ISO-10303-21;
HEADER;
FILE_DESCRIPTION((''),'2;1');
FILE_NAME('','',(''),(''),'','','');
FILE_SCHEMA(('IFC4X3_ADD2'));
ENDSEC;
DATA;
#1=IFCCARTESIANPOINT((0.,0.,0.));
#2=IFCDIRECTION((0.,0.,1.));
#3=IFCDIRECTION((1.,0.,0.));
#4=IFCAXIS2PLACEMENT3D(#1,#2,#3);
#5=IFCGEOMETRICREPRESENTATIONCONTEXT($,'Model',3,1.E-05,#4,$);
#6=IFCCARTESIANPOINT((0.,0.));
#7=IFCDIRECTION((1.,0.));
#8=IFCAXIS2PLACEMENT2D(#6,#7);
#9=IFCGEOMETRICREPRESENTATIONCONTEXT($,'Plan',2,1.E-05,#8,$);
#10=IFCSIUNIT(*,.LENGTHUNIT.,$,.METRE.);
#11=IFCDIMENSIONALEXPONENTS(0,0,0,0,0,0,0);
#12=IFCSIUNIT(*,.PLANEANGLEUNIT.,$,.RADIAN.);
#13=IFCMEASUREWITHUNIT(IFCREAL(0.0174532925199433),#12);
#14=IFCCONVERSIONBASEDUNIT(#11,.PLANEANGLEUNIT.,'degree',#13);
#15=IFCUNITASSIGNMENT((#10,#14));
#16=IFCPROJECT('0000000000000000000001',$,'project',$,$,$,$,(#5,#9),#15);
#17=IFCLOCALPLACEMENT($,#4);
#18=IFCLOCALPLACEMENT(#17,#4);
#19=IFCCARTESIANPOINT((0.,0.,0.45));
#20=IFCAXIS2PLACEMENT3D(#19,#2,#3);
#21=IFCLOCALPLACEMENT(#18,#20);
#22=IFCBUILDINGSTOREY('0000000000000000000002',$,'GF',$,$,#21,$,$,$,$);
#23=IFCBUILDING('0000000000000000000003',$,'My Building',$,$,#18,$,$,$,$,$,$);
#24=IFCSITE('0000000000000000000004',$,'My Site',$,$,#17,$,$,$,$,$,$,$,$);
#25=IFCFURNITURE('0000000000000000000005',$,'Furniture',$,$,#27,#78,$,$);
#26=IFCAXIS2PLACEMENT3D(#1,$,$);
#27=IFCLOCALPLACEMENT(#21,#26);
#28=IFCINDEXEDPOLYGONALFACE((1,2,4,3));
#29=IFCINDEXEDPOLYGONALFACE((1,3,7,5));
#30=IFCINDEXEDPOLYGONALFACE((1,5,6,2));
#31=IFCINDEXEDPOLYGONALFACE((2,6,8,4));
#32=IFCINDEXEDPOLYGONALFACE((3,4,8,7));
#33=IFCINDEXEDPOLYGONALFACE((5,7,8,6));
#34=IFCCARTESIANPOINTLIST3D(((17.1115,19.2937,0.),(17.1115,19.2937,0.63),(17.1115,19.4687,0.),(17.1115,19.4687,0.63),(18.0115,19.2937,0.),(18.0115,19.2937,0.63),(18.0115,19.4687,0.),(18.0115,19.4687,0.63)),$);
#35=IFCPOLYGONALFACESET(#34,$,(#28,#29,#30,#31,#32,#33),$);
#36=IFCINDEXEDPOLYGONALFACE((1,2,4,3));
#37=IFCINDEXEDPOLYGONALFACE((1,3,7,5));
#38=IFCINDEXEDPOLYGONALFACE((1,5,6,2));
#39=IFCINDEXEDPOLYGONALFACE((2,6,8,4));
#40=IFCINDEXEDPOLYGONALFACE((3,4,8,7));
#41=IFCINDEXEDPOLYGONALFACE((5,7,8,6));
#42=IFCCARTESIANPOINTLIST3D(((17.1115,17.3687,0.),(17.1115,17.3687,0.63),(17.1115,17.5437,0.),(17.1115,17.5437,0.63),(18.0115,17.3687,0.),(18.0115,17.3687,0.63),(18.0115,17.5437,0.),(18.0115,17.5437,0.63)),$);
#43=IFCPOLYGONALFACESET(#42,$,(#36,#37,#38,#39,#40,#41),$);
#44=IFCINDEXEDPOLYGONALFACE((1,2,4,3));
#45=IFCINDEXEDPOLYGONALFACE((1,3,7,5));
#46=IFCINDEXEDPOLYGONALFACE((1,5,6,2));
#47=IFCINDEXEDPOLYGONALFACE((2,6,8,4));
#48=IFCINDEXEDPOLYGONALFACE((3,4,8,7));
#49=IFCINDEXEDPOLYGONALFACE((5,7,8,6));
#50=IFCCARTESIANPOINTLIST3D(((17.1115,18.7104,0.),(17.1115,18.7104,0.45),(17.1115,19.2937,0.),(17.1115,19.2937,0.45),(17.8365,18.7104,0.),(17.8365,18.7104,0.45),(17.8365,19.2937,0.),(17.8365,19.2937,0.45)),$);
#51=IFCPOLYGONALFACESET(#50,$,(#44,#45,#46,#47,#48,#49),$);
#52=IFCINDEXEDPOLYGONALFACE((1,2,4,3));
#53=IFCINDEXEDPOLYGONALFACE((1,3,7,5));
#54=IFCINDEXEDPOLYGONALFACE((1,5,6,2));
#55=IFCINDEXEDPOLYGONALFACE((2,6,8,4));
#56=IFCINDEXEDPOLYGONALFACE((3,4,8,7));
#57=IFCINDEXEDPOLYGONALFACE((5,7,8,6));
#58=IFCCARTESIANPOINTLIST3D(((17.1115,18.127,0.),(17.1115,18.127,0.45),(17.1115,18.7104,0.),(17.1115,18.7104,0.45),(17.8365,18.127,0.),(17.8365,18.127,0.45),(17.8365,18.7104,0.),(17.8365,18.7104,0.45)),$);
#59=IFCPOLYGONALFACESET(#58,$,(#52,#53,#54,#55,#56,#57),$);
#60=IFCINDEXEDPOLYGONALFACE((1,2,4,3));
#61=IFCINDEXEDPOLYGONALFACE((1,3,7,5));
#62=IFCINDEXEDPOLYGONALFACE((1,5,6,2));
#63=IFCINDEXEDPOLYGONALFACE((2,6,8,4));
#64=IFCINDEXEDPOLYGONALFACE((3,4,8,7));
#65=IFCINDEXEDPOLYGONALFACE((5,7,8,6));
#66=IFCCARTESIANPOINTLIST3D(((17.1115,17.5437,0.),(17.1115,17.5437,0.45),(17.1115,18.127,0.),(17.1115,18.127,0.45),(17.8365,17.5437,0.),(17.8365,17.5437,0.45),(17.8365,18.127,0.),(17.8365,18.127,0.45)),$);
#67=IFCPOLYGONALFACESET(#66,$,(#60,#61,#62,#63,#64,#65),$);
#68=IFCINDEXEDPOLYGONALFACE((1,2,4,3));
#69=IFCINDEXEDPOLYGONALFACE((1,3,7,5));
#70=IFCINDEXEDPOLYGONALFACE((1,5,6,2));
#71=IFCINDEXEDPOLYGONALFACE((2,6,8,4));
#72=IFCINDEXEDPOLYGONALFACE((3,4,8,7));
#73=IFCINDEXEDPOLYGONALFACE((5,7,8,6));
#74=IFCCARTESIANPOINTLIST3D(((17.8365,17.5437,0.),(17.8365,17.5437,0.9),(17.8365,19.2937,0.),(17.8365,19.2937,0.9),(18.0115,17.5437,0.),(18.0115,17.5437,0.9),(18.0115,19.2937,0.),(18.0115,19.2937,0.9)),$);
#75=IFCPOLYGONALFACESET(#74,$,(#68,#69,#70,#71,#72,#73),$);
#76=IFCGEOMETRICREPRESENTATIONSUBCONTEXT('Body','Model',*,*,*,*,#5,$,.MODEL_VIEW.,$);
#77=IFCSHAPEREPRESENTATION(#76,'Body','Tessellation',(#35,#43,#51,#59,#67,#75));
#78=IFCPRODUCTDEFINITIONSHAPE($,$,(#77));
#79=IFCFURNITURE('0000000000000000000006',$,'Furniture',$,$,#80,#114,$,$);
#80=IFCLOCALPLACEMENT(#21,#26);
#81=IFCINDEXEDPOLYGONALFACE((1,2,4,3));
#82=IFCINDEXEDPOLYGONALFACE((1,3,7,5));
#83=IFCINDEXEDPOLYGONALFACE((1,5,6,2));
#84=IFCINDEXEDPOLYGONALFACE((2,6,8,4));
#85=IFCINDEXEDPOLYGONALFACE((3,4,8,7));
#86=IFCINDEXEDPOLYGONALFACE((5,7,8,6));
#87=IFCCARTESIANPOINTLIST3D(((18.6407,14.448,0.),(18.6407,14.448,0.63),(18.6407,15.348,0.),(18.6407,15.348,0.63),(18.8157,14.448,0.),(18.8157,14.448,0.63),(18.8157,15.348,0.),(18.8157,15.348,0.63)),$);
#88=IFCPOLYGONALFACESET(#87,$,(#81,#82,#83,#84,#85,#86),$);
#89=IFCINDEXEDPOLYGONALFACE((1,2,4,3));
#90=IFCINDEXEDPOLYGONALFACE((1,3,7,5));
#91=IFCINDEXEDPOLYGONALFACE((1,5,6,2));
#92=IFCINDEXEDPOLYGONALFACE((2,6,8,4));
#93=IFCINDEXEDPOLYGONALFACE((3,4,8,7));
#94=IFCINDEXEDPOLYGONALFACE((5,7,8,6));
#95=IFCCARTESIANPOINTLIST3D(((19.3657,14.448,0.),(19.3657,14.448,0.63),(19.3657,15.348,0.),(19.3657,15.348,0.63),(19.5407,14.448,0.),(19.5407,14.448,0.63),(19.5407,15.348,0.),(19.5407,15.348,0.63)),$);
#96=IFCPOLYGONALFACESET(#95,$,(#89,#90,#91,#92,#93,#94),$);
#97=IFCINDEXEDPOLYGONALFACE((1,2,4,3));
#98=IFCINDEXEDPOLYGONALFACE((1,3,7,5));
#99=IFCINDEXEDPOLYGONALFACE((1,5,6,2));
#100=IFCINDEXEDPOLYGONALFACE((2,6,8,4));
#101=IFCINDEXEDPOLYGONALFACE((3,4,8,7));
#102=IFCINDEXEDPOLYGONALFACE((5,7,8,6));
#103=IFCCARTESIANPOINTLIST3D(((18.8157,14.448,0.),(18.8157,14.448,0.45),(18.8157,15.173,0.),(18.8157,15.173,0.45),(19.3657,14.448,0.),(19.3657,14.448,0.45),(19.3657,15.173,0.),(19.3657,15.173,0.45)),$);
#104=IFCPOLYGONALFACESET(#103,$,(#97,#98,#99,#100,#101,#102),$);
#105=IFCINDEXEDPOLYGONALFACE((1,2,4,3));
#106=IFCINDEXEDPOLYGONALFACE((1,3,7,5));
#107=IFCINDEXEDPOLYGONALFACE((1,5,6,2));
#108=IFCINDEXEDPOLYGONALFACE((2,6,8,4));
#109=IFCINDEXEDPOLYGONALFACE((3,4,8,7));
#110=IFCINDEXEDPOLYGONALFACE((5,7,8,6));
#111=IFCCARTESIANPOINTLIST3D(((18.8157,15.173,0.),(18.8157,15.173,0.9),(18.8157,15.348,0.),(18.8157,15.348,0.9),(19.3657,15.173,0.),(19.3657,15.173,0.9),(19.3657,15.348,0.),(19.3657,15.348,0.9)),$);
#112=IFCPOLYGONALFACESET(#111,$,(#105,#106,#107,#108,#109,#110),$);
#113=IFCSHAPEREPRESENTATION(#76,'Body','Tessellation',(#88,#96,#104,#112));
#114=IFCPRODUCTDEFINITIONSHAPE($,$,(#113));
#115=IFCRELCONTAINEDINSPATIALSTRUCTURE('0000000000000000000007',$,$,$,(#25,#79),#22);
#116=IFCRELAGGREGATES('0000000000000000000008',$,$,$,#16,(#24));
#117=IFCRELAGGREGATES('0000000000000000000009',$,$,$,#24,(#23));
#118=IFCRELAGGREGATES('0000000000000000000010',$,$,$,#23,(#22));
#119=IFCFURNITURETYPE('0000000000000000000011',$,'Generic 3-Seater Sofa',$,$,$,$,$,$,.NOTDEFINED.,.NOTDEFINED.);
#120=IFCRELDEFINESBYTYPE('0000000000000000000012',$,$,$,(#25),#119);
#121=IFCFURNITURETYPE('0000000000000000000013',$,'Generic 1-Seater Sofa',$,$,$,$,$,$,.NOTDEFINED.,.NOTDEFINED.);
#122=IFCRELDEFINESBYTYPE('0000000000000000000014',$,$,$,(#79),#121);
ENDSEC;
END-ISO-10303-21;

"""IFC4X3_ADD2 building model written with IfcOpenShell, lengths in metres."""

from ifc_helpers import new_model, entity, si_unit, converted_unit, frame, origin_with_axes, origin_2d_with_axis, place, context, subcontext, project, spatial, line, indexed_curve, outline, extrude, shape, source, transform, mapped, type_object, type_shapes, element, save


model = new_model("IFC4X3_ADD2")

# Units and contexts
model_context = context("Model", 3, precision=1e-05, world=origin_with_axes())
plan_context = context("Plan", 2, precision=1e-05, world=origin_2d_with_axis())
body_context_1 = subcontext(model_context, "Body", "Model", "MODEL_VIEW")
body_context_2 = subcontext(plan_context, "Body", "Plan", "PLAN_VIEW")
ifc_project = project(units=[si_unit("LENGTHUNIT", "METRE"), converted_unit("PLANEANGLEUNIT", "degree", entity("IfcReal", 0.0174532925199433), si_unit("PLANEANGLEUNIT", "RADIAN"), dimensions=[0, 0, 0, 0, 0, 0, 0])], contexts=[model_context, plan_context])

# Site, building, storey
site_placement = place(None, origin_with_axes())
site = spatial("IfcSite", under=ifc_project, at=site_placement, Name="My Site")
building_placement = place(site_placement, origin_with_axes())
building = spatial("IfcBuilding", under=site, at=building_placement, Name="My Building")
storey_placement = place(building_placement, frame((0.0, 0.0, 0.45), z_axis=(0.0, 0.0, 1.0), x_axis=(1.0, 0.0, 0.0)))
storey = spatial("IfcBuildingStorey", under=building, at=storey_placement, Name="GF")

# Furniture
furniture_type_1 = type_object("IfcFurnitureType", Name="Generic 3-Seater Sofa", AssemblyPlace="NOTDEFINED", PredefinedType="NOTDEFINED")
shared_shape_1 = source(origin_with_axes(), body_context_1, "Body", "SweptSolid", [
    extrude(outline(indexed_curve([(0.0, 0.0), (0.175, 0.0), (0.175, 0.9), (0.0, 0.9)], segments=[line(1, 2, 3, 4, 1)])), frame((-1.05, -0.9, 0.0), z_axis=(0.0, 0.0, 1.0), x_axis=(1.0, 0.0, 0.0)), (0.0, 0.0, 1.0), 0.63),
    extrude(outline(indexed_curve([(0.0, 0.0), (0.175, 0.0), (0.175, 0.9), (0.0, 0.9)], segments=[line(1, 2, 3, 4, 1)])), frame((0.875, -0.9, 0.0), z_axis=(0.0, 0.0, 1.0), x_axis=(1.0, 0.0, 0.0)), (0.0, 0.0, 1.0), 0.63),
    extrude(outline(indexed_curve([(0.175, 0.0), (0.7583, 0.0), (0.7583, 0.725), (0.175, 0.725)], segments=[line(1, 2, 3, 4, 1)])), frame((-1.05, -0.9, 0.0), z_axis=(0.0, 0.0, 1.0), x_axis=(1.0, 0.0, 0.0)), (0.0, 0.0, 1.0), 0.45),
    extrude(outline(indexed_curve([(0.7583, 0.0), (1.3417, 0.0), (1.3417, 0.725), (0.7583, 0.725)], segments=[line(1, 2, 3, 4, 1)])), frame((-1.05, -0.9, 0.0), z_axis=(0.0, 0.0, 1.0), x_axis=(1.0, 0.0, 0.0)), (0.0, 0.0, 1.0), 0.45),
    extrude(outline(indexed_curve([(1.3417, 0.0), (1.925, 0.0), (1.925, 0.725), (1.3417, 0.725)], segments=[line(1, 2, 3, 4, 1)])), frame((-1.05, -0.9, 0.0), z_axis=(0.0, 0.0, 1.0), x_axis=(1.0, 0.0, 0.0)), (0.0, 0.0, 1.0), 0.45),
    extrude(outline(indexed_curve([(0.175, 0.725), (1.925, 0.725), (1.925, 0.9), (0.175, 0.9)], segments=[line(1, 2, 3, 4, 1)])), frame((-1.05, -0.9, 0.0), z_axis=(0.0, 0.0, 1.0), x_axis=(1.0, 0.0, 0.0)), (0.0, 0.0, 1.0), 0.9),
])
shared_shape_2 = source(origin_with_axes(), body_context_2, "Body", "Curve2D", [
    entity("IfcIndexedPolyCurve", entity("IfcCartesianPointList2D", [[-1.05, -0.9], [-0.875, -0.9], [-0.875, 0.0], [-1.05, 0.0]]), [entity("IfcLineIndex", [1, 2, 3, 4, 1])]),
    entity("IfcIndexedPolyCurve", entity("IfcCartesianPointList2D", [[0.875, -0.9], [1.05, -0.9], [1.05, 0.0], [0.875, 0.0]]), [entity("IfcLineIndex", [1, 2, 3, 4, 1])]),
    entity("IfcIndexedPolyCurve", entity("IfcCartesianPointList2D", [[-0.875, -0.9], [-0.2917, -0.9], [-0.2917, -0.175], [-0.875, -0.175]]), [entity("IfcLineIndex", [1, 2, 3, 4, 1])]),
    entity("IfcIndexedPolyCurve", entity("IfcCartesianPointList2D", [[-0.2917, -0.9], [0.2917, -0.9], [0.2917, -0.175], [-0.2917, -0.175]]), [entity("IfcLineIndex", [1, 2, 3, 4, 1])]),
    entity("IfcIndexedPolyCurve", entity("IfcCartesianPointList2D", [[0.2917, -0.9], [0.875, -0.9], [0.875, -0.175], [0.2917, -0.175]]), [entity("IfcLineIndex", [1, 2, 3, 4, 1])]),
    entity("IfcIndexedPolyCurve", entity("IfcCartesianPointList2D", [[-0.875, -0.175], [0.875, -0.175], [0.875, 0.0], [-0.875, 0.0]]), [entity("IfcLineIndex", [1, 2, 3, 4, 1])]),
])
type_shapes(furniture_type_1, [shared_shape_1, shared_shape_2])
furniture_1_placement = place(storey_placement, frame((18.0115, 18.4187, 0.0), z_axis=(0.0, 0.0, 1.0), x_axis=(0.0, -1.0, 0.0)))
element("IfcFurniture", 1, at=furniture_1_placement, inside=storey, type_object=furniture_type_1, Name="Furniture", shapes=[
    shape(body_context_1, "Body", "MappedRepresentation", [mapped(shared_shape_1, transform((0.0, 0.0, 0.0), x_axis=(1.0, 0.0, 0.0), y_axis=(0.0, 1.0, 0.0), z_axis=(0.0, 0.0, 1.0), scale=1.0))]),
    shape(body_context_2, "Body", "MappedRepresentation", [mapped(shared_shape_2, transform((0.0, 0.0, 0.0), x_axis=(1.0, 0.0, 0.0), y_axis=(0.0, 1.0, 0.0), z_axis=(0.0, 0.0, 1.0), scale=1.0))]),
])
furniture_type_2 = type_object("IfcFurnitureType", Name="Generic 1-Seater Sofa", AssemblyPlace="NOTDEFINED", PredefinedType="NOTDEFINED")
shared_shape_3 = source(origin_with_axes(), body_context_1, "Body", "SweptSolid", [
    extrude(outline(indexed_curve([(0.0, 0.0), (0.175, 0.0), (0.175, 0.9), (0.0, 0.9)], segments=[line(1, 2, 3, 4, 1)])), frame((-0.45, -0.9, 0.0), z_axis=(0.0, 0.0, 1.0), x_axis=(1.0, 0.0, 0.0)), (0.0, 0.0, 1.0), 0.63),
    extrude(outline(indexed_curve([(0.0, 0.0), (0.175, 0.0), (0.175, 0.9), (0.0, 0.9)], segments=[line(1, 2, 3, 4, 1)])), frame((0.275, -0.9, 0.0), z_axis=(0.0, 0.0, 1.0), x_axis=(1.0, 0.0, 0.0)), (0.0, 0.0, 1.0), 0.63),
    extrude(outline(indexed_curve([(0.175, 0.0), (0.725, 0.0), (0.725, 0.725), (0.175, 0.725)], segments=[line(1, 2, 3, 4, 1)])), frame((-0.45, -0.9, 0.0), z_axis=(0.0, 0.0, 1.0), x_axis=(1.0, 0.0, 0.0)), (0.0, 0.0, 1.0), 0.45),
    extrude(outline(indexed_curve([(0.175, 0.725), (0.725, 0.725), (0.725, 0.9), (0.175, 0.9)], segments=[line(1, 2, 3, 4, 1)])), frame((-0.45, -0.9, 0.0), z_axis=(0.0, 0.0, 1.0), x_axis=(1.0, 0.0, 0.0)), (0.0, 0.0, 1.0), 0.9),
])
shared_shape_4 = source(origin_with_axes(), body_context_2, "Body", "Annotation2D", [
    entity("IfcGeometricCurveSet", [entity("IfcIndexedPolyCurve", entity("IfcCartesianPointList2D", [[0.275, -0.175], [0.275, -0.9], [0.45, -0.9], [0.45, 0.0], [0.275, 0.0], [0.275, -0.9], [-0.275, -0.9], [-0.275, 0.0], [-0.275, -0.175], [0.275, -0.175], [0.275, 0.0], [-0.275, 0.0], [-0.45, 0.0], [-0.45, -0.9], [-0.275, -0.9], [-0.275, -0.175]]))]),
])
type_shapes(furniture_type_2, [shared_shape_3, shared_shape_4])
furniture_2_placement = place(storey_placement, frame((19.0907, 15.348, 0.0), z_axis=(0.0, 0.0, 1.0), x_axis=(1.0, 0.0, 0.0)))
element("IfcFurniture", 2, at=furniture_2_placement, inside=storey, type_object=furniture_type_2, Name="Furniture", shapes=[
    shape(body_context_1, "Body", "MappedRepresentation", [mapped(shared_shape_3, transform((0.0, 0.0, 0.0), x_axis=(1.0, 0.0, 0.0), y_axis=(0.0, 1.0, 0.0), z_axis=(0.0, 0.0, 1.0), scale=1.0))]),
    shape(body_context_2, "Body", "MappedRepresentation", [mapped(shared_shape_4, transform((0.0, 0.0, 0.0), x_axis=(1.0, 0.0, 0.0), y_axis=(0.0, 1.0, 0.0), z_axis=(0.0, 0.0, 1.0), scale=1.0))]),
])

save(model, "model.ifc")
